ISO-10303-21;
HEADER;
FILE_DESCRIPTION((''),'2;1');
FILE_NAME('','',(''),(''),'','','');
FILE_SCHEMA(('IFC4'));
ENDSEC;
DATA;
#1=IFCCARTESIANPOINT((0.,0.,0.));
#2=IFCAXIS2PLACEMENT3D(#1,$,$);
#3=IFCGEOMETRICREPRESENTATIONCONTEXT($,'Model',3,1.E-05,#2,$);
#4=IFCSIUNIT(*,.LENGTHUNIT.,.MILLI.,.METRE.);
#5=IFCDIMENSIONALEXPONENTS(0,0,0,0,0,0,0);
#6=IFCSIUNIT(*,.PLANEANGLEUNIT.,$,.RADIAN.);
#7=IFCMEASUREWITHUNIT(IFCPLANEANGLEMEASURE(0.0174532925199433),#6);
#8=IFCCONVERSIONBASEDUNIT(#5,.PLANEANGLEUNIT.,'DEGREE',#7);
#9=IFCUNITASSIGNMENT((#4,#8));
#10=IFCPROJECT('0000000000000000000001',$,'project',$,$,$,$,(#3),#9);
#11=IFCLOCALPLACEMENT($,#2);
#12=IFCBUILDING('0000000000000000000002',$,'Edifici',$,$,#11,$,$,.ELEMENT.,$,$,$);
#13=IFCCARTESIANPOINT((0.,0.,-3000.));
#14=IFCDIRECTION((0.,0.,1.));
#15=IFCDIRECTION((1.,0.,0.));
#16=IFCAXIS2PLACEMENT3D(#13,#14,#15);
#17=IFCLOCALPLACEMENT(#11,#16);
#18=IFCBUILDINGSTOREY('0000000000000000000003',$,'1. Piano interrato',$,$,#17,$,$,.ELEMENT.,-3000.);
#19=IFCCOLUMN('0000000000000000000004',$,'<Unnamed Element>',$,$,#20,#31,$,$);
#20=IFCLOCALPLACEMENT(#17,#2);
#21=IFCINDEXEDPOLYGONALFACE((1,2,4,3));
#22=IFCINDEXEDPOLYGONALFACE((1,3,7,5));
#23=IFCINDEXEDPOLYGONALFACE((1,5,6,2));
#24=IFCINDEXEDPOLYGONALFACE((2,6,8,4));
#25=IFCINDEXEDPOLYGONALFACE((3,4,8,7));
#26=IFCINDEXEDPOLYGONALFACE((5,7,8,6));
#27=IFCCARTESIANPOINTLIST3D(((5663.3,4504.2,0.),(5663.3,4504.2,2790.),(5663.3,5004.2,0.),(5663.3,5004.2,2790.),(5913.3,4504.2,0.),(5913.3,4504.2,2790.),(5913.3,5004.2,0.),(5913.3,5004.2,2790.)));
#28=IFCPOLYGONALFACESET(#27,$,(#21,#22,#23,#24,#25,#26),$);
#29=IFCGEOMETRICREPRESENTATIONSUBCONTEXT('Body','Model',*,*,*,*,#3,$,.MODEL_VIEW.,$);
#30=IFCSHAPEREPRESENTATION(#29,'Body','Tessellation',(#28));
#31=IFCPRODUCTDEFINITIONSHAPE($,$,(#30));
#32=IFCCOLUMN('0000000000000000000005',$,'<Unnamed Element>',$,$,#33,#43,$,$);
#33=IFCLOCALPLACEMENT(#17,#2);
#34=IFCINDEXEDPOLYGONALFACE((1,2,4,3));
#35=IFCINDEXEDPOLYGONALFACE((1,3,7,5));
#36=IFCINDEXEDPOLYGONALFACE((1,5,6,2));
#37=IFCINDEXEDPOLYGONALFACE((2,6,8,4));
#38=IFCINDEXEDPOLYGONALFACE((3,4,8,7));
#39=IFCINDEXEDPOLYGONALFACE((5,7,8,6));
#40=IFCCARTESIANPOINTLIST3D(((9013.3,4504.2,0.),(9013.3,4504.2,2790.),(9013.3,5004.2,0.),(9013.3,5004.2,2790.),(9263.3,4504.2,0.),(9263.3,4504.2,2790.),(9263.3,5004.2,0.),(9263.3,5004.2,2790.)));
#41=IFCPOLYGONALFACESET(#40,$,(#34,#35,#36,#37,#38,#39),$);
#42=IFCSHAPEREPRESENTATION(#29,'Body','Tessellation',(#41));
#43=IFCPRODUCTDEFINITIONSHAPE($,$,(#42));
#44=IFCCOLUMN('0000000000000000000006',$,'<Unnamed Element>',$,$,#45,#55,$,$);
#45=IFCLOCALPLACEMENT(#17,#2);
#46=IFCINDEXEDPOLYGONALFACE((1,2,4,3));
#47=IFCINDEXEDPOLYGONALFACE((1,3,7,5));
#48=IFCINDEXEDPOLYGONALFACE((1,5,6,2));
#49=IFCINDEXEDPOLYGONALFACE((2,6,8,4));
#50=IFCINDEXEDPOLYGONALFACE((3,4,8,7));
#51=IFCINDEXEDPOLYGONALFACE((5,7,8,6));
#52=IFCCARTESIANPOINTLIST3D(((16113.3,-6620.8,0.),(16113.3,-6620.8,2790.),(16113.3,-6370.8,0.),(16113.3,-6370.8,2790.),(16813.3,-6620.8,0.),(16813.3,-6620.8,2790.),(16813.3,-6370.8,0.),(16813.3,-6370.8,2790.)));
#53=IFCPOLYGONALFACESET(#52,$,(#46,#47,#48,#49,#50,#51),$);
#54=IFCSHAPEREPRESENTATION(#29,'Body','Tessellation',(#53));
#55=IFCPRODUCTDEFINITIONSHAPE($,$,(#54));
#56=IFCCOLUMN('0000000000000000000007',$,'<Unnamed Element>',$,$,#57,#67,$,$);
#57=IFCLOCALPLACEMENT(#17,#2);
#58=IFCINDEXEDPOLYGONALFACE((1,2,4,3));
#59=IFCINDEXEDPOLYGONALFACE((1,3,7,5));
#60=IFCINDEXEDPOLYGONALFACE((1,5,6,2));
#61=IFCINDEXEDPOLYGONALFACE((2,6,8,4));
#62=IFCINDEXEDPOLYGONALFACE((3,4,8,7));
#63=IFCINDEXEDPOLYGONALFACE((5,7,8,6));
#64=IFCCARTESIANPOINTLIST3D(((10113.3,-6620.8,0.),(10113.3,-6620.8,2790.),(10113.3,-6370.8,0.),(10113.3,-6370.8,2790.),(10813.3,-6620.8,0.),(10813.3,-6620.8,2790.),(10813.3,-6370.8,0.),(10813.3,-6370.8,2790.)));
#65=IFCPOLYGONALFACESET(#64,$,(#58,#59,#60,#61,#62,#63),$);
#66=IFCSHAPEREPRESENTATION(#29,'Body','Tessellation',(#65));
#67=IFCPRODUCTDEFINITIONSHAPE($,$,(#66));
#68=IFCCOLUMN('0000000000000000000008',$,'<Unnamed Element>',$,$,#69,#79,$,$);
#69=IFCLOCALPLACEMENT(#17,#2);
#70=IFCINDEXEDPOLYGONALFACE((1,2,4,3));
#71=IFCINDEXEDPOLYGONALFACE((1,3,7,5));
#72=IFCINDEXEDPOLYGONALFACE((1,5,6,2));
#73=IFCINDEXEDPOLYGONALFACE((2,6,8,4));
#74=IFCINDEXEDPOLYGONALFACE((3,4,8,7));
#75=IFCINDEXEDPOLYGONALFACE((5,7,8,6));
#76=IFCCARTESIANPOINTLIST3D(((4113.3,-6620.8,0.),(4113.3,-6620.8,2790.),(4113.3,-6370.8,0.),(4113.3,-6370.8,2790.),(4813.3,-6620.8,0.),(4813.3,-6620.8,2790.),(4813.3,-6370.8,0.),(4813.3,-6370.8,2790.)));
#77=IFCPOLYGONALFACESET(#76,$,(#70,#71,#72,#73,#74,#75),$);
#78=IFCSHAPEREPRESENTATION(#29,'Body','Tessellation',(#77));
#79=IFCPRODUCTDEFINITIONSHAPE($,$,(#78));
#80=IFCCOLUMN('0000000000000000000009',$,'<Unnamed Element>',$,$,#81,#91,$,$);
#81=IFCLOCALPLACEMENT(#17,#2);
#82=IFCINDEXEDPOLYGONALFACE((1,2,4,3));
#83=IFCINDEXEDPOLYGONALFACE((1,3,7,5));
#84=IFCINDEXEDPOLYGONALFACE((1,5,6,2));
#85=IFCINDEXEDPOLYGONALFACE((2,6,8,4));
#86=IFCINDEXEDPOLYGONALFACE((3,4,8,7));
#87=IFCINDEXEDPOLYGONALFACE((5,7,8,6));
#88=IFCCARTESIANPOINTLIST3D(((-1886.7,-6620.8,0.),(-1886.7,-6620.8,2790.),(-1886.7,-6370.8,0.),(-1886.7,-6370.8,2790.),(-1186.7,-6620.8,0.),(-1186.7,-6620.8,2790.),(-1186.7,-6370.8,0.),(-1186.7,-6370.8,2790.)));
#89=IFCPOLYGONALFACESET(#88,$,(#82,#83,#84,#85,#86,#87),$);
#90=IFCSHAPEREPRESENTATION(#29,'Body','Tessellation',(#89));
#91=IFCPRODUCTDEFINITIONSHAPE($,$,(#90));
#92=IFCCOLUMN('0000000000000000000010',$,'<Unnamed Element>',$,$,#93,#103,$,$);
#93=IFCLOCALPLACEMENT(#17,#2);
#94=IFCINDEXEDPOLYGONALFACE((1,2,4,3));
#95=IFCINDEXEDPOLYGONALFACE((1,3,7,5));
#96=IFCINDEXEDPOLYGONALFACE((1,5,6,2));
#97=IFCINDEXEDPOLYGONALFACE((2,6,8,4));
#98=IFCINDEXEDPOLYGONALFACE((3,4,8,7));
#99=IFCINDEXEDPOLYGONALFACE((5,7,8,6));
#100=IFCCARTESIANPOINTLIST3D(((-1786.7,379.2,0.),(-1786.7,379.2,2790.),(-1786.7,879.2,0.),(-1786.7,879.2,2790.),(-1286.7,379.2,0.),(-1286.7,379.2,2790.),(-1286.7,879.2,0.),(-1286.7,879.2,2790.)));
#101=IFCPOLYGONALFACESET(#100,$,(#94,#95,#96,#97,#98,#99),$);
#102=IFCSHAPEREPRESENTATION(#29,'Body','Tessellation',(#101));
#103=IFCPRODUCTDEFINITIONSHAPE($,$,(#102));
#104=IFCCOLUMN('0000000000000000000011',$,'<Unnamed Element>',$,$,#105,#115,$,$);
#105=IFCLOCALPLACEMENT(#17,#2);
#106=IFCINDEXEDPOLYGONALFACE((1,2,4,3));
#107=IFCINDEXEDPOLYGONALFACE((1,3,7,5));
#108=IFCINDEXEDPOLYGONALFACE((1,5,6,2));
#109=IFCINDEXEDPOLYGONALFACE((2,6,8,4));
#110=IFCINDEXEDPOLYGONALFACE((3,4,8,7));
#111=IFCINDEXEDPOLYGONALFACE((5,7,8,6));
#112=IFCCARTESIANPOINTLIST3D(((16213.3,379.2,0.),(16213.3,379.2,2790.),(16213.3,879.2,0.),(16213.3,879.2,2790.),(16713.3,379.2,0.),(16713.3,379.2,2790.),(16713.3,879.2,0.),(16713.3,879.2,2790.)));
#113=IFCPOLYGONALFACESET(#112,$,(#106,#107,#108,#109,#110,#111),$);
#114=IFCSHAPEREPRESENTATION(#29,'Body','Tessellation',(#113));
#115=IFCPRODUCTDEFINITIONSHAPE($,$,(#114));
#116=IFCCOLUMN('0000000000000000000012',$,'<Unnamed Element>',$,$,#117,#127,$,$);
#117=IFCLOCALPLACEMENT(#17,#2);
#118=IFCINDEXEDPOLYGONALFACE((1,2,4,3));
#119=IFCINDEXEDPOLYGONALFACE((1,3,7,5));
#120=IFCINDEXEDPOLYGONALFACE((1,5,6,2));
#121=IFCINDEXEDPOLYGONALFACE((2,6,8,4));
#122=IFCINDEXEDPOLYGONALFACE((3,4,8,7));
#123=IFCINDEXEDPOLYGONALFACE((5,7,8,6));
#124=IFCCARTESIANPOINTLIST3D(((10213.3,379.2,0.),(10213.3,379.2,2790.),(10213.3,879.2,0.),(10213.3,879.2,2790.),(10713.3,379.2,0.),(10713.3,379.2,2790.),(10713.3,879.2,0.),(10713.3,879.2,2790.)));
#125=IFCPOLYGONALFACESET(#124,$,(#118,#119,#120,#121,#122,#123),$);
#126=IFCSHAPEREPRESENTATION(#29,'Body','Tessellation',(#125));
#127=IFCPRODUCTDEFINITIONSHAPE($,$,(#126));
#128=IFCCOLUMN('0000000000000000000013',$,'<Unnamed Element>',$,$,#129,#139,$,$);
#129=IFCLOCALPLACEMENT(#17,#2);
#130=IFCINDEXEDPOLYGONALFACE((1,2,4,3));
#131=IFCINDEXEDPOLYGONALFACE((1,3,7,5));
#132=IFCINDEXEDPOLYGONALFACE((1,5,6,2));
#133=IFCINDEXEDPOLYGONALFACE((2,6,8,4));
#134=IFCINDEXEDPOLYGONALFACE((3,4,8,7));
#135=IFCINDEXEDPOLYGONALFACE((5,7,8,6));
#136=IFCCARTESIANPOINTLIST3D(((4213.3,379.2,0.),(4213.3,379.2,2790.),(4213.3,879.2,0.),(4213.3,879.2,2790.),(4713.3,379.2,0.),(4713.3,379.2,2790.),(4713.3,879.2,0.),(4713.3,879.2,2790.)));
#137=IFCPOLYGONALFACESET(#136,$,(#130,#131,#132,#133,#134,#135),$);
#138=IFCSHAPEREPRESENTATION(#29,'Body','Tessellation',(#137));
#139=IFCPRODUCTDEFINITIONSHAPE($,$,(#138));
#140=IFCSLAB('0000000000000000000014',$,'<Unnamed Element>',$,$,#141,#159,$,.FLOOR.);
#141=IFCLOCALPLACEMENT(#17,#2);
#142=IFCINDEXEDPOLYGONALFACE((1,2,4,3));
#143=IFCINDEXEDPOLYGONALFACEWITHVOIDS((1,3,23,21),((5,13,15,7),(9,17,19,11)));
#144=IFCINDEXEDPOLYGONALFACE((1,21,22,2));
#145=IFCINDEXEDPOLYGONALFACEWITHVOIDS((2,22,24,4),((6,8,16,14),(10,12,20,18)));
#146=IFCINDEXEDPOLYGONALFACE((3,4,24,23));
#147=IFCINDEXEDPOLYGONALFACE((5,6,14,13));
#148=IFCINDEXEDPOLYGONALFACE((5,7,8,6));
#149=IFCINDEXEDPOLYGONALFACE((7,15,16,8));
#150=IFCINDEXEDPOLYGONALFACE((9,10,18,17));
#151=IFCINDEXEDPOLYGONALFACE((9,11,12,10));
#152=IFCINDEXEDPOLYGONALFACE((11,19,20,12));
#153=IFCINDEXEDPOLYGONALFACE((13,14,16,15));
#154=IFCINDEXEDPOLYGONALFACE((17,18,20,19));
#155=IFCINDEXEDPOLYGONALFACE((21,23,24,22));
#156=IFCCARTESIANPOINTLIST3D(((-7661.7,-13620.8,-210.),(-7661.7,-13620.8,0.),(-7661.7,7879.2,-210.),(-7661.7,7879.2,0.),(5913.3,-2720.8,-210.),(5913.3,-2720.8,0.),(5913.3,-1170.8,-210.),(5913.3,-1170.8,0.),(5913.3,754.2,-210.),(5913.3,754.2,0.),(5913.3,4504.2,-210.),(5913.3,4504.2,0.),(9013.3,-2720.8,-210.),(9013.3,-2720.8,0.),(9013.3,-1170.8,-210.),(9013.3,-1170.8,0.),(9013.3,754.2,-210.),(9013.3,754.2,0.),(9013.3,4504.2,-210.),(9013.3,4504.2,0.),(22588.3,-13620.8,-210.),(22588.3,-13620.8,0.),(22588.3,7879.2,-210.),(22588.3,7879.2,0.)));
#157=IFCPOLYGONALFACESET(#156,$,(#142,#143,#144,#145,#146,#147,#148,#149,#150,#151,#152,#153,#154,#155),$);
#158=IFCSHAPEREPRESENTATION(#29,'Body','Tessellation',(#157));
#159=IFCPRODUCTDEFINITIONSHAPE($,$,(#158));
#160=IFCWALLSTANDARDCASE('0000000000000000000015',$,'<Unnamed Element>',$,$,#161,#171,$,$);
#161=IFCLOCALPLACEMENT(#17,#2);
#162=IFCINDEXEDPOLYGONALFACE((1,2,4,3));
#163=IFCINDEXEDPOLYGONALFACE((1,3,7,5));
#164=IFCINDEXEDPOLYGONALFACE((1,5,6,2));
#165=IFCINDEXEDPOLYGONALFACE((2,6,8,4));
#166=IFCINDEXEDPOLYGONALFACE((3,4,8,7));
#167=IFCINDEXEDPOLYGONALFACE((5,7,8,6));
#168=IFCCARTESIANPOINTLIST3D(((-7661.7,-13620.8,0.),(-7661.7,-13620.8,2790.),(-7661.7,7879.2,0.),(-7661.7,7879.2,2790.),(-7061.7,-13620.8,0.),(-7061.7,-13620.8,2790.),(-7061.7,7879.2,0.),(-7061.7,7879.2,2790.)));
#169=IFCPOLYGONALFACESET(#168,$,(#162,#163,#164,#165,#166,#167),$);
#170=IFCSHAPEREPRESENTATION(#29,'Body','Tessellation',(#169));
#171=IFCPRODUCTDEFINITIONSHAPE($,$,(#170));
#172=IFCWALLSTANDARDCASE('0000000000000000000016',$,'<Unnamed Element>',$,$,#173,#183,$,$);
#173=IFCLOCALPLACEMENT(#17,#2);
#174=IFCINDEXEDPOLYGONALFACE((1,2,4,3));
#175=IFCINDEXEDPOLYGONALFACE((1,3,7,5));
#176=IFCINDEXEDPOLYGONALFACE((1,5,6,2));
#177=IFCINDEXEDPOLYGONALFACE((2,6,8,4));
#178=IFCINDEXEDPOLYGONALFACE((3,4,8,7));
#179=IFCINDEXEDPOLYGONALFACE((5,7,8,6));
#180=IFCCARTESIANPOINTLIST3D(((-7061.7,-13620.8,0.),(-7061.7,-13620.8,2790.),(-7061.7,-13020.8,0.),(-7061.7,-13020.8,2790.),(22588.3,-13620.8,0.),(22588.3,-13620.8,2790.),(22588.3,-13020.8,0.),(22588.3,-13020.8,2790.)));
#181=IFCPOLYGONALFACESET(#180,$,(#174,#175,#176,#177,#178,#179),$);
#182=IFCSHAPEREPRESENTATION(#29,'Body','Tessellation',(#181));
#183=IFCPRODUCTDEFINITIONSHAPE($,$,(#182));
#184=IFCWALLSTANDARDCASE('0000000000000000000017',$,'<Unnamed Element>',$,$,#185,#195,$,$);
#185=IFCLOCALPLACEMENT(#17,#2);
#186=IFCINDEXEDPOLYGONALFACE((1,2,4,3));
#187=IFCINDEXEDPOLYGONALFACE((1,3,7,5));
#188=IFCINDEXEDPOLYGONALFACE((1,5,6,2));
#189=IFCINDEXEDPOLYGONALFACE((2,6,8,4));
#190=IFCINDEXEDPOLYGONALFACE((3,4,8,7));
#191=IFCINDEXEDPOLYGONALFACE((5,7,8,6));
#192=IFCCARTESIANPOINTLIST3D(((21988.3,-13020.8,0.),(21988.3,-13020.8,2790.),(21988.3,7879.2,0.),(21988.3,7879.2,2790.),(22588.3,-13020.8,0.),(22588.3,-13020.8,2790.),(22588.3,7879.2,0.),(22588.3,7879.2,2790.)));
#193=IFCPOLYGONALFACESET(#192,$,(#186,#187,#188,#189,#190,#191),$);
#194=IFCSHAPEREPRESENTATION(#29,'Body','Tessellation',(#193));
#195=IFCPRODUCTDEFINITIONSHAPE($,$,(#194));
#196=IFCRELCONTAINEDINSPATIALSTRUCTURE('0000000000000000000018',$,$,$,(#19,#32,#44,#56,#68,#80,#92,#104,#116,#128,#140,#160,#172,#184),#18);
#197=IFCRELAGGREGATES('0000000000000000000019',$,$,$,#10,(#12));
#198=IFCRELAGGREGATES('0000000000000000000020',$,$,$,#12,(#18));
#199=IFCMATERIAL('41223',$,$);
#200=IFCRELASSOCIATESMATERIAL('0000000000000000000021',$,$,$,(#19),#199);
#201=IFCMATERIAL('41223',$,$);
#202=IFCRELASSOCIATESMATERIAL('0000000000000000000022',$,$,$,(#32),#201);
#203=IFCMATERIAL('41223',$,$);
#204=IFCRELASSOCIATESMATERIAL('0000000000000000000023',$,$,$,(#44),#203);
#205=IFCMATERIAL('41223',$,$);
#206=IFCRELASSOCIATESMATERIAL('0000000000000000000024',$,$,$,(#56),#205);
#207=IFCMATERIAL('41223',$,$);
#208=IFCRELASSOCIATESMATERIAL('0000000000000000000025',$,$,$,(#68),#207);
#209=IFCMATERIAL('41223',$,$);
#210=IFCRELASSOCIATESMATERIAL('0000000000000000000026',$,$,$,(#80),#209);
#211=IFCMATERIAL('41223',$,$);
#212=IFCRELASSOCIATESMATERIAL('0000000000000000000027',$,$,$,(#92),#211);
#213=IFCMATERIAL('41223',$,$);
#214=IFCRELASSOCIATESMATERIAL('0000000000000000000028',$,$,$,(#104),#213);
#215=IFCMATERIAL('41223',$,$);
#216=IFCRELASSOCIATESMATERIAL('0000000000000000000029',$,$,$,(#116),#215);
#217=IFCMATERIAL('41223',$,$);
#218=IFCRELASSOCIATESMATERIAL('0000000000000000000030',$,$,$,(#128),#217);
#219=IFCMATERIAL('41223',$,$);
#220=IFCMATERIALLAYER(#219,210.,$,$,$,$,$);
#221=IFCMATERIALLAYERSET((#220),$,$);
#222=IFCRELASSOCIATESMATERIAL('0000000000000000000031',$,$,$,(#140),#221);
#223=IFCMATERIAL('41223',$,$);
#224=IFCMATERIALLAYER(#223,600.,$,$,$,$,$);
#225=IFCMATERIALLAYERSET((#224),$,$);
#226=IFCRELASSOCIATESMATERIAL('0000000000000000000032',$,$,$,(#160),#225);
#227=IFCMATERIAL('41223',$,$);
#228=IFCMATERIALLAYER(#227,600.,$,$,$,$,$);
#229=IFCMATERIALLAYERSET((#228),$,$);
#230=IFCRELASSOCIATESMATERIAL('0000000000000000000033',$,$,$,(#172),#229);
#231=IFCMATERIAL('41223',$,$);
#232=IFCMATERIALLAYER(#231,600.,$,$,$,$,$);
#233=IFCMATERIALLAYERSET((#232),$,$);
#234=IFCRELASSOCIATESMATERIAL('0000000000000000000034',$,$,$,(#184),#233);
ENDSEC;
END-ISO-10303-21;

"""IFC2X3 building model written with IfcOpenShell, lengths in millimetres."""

from ifc_helpers import new_model, entity, si_unit, converted_unit, frame, frame_2d, origin, origin_with_axes, place, context, subcontext, project, spatial, polyline, rectangle, outline, extrude, material, layer, layer_set, layer_usage, element, save


model = new_model("IFC2X3")

# Units and contexts
model_context = context("Model", 3, precision=1e-05, world=origin())
body_context = subcontext(model_context, "Body", "Model", "MODEL_VIEW")
ifc_project = project(units=[si_unit("LENGTHUNIT", "METRE", prefix="MILLI"), converted_unit("PLANEANGLEUNIT", "DEGREE", entity("IfcPlaneAngleMeasure", 0.0174532925199433), si_unit("PLANEANGLEUNIT", "RADIAN"), dimensions=[0, 0, 0, 0, 0, 0, 0])], contexts=[model_context])

# Building, storey
building_placement = place(None, origin())
building = spatial("IfcBuilding", under=ifc_project, at=building_placement, Name="Edifici", CompositionType="ELEMENT")
storey_placement = place(building_placement, frame((0.0, 0.0, -3000.0), z_axis=(0.0, 0.0, 1.0), x_axis=(1.0, 0.0, 0.0)))
storey = spatial("IfcBuildingStorey", under=building, at=storey_placement, Name="1. Piano interrato", CompositionType="ELEMENT", Elevation=-3000.0)

# Columns
ifc_material_1 = material(Name="41223")
column_1_placement = place(storey_placement, frame((5913.3, 5004.2, 0.0), z_axis=(0.0, 0.0, 1.0), x_axis=(1.0, 0.0, 0.0)))
element("IfcColumn", 1, at=column_1_placement, inside=storey, material=ifc_material_1, Name="<Unnamed Element>", context=body_context, shape_type="SweptSolid", body=[
    extrude(rectangle(XDim=250.0, YDim=500.0, at=frame_2d((-125.0, -250.0), x_axis=(-1.0, 0.0))), origin_with_axes(), (0.0, 0.0, 1.0), 2790.0),
])
ifc_material_2 = material(Name="41223")
column_2_placement = place(storey_placement, frame((9263.3, 5004.2, 0.0), z_axis=(0.0, 0.0, 1.0), x_axis=(1.0, 0.0, 0.0)))
element("IfcColumn", 2, at=column_2_placement, inside=storey, material=ifc_material_2, Name="<Unnamed Element>", context=body_context, shape_type="SweptSolid", body=[
    extrude(rectangle(XDim=250.0, YDim=500.0, at=frame_2d((-125.0, -250.0), x_axis=(-1.0, 0.0))), origin_with_axes(), (0.0, 0.0, 1.0), 2790.0),
])
ifc_material_3 = material(Name="41223")
column_3_placement = place(storey_placement, frame((16813.3, -6620.8, 0.0), z_axis=(0.0, 0.0, 1.0), x_axis=(1.0, 0.0, 0.0)))
element("IfcColumn", 3, at=column_3_placement, inside=storey, material=ifc_material_3, Name="<Unnamed Element>", context=body_context, shape_type="SweptSolid", body=[
    extrude(rectangle(XDim=250.0, YDim=700.0, at=frame_2d((-350.0, 125.0), x_axis=(0.0, 1.0))), origin_with_axes(), (0.0, 0.0, 1.0), 2790.0),
])
ifc_material_4 = material(Name="41223")
column_4_placement = place(storey_placement, frame((10813.3, -6620.8, 0.0), z_axis=(0.0, 0.0, 1.0), x_axis=(1.0, 0.0, 0.0)))
element("IfcColumn", 4, at=column_4_placement, inside=storey, material=ifc_material_4, Name="<Unnamed Element>", context=body_context, shape_type="SweptSolid", body=[
    extrude(rectangle(XDim=250.0, YDim=700.0, at=frame_2d((-350.0, 125.0), x_axis=(0.0, 1.0))), origin_with_axes(), (0.0, 0.0, 1.0), 2790.0),
])
ifc_material_5 = material(Name="41223")
column_5_placement = place(storey_placement, frame((4813.3, -6620.8, 0.0), z_axis=(0.0, 0.0, 1.0), x_axis=(1.0, 0.0, 0.0)))
element("IfcColumn", 5, at=column_5_placement, inside=storey, material=ifc_material_5, Name="<Unnamed Element>", context=body_context, shape_type="SweptSolid", body=[
    extrude(rectangle(XDim=250.0, YDim=700.0, at=frame_2d((-350.0, 125.0), x_axis=(0.0, 1.0))), origin_with_axes(), (0.0, 0.0, 1.0), 2790.0),
])
ifc_material_6 = material(Name="41223")
column_6_placement = place(storey_placement, frame((-1186.7, -6620.8, 0.0), z_axis=(0.0, 0.0, 1.0), x_axis=(1.0, 0.0, 0.0)))
element("IfcColumn", 6, at=column_6_placement, inside=storey, material=ifc_material_6, Name="<Unnamed Element>", context=body_context, shape_type="SweptSolid", body=[
    extrude(rectangle(XDim=250.0, YDim=700.0, at=frame_2d((-350.0, 125.0), x_axis=(0.0, 1.0))), origin_with_axes(), (0.0, 0.0, 1.0), 2790.0),
])
ifc_material_7 = material(Name="41223")
column_7_placement = place(storey_placement, frame((-1786.7, 379.2, 0.0), z_axis=(0.0, 0.0, 1.0), x_axis=(1.0, 0.0, 0.0)))
element("IfcColumn", 7, at=column_7_placement, inside=storey, material=ifc_material_7, Name="<Unnamed Element>", context=body_context, shape_type="SweptSolid", body=[
    extrude(rectangle(XDim=500.0, YDim=500.0, at=frame_2d((250.0, 250.0), x_axis=(1.0, 0.0))), origin_with_axes(), (0.0, 0.0, 1.0), 2790.0),
])
ifc_material_8 = material(Name="41223")
column_8_placement = place(storey_placement, frame((16213.3, 379.2, 0.0), z_axis=(0.0, 0.0, 1.0), x_axis=(1.0, 0.0, 0.0)))
element("IfcColumn", 8, at=column_8_placement, inside=storey, material=ifc_material_8, Name="<Unnamed Element>", context=body_context, shape_type="SweptSolid", body=[
    extrude(rectangle(XDim=500.0, YDim=500.0, at=frame_2d((250.0, 250.0), x_axis=(1.0, 0.0))), origin_with_axes(), (0.0, 0.0, 1.0), 2790.0),
])
ifc_material_9 = material(Name="41223")
column_9_placement = place(storey_placement, frame((10213.3, 379.2, 0.0), z_axis=(0.0, 0.0, 1.0), x_axis=(1.0, 0.0, 0.0)))
element("IfcColumn", 9, at=column_9_placement, inside=storey, material=ifc_material_9, Name="<Unnamed Element>", context=body_context, shape_type="SweptSolid", body=[
    extrude(rectangle(XDim=500.0, YDim=500.0, at=frame_2d((250.0, 250.0), x_axis=(1.0, 0.0))), origin_with_axes(), (0.0, 0.0, 1.0), 2790.0),
])
ifc_material_10 = material(Name="41223")
column_10_placement = place(storey_placement, frame((4213.3, 379.2, 0.0), z_axis=(0.0, 0.0, 1.0), x_axis=(1.0, 0.0, 0.0)))
element("IfcColumn", 10, at=column_10_placement, inside=storey, material=ifc_material_10, Name="<Unnamed Element>", context=body_context, shape_type="SweptSolid", body=[
    extrude(rectangle(XDim=500.0, YDim=500.0, at=frame_2d((250.0, 250.0), x_axis=(1.0, 0.0))), origin_with_axes(), (0.0, 0.0, 1.0), 2790.0),
])

# Slab
ifc_material_11 = material(Name="41223")
ifc_layer_1 = layer(ifc_material_11, 210.0)
ifc_layer_set_1 = layer_set([ifc_layer_1])
ifc_layer_usage_1 = layer_usage(ifc_layer_set_1, "AXIS3", "POSITIVE", 0.0)
slab_placement = place(storey_placement, frame((-7661.7, -13620.8, -210.0), z_axis=(0.0, 0.0, 1.0), x_axis=(1.0, 0.0, 0.0)))
element("IfcSlab", 11, at=slab_placement, inside=storey, material=ifc_layer_usage_1, Name="<Unnamed Element>", PredefinedType="FLOOR", context=body_context, shape_type="SweptSolid", body=[
    extrude(outline(polyline([(0.0, 0.0), (30250.0, 0.0), (30250.0, 21500.0), (0.0, 21500.0), (0.0, 0.0)]), holes=[polyline([(13575.0, 18125.0), (16675.0, 18125.0), (16675.0, 14375.0), (13575.0, 14375.0), (13575.0, 18125.0)]), polyline([(16675.0, 10900.0), (13575.0, 10900.0), (13575.0, 12450.0), (16675.0, 12450.0), (16675.0, 10900.0)])]), origin_with_axes(), (0.0, 0.0, 1.0), 210.0),
])

# Walls
ifc_material_12 = material(Name="41223")
ifc_layer_2 = layer(ifc_material_12, 600.0)
ifc_layer_set_2 = layer_set([ifc_layer_2])
ifc_layer_usage_2 = layer_usage(ifc_layer_set_2, "AXIS2", "POSITIVE", 0.0)
wall_1_placement = place(storey_placement, frame((-7661.7, 7879.2, 0.0), z_axis=(0.0, 0.0, 1.0), x_axis=(0.0, -1.0, 0.0)))
element("IfcWallStandardCase", 12, at=wall_1_placement, inside=storey, material=ifc_layer_usage_2, Name="<Unnamed Element>", context=body_context, shape_type="SweptSolid", body=[
    extrude(rectangle(XDim=21500.0, YDim=600.0, at=frame_2d((10750.0, 300.0), x_axis=(1.0, 0.0))), origin_with_axes(), (0.0, 0.0, 1.0), 2790.0),
])
ifc_material_13 = material(Name="41223")
ifc_layer_3 = layer(ifc_material_13, 600.0)
ifc_layer_set_3 = layer_set([ifc_layer_3])
ifc_layer_usage_3 = layer_usage(ifc_layer_set_3, "AXIS2", "POSITIVE", 0.0)
wall_2_placement = place(storey_placement, frame((-7061.7, -13620.8, 0.0), z_axis=(0.0, 0.0, 1.0), x_axis=(1.0, 0.0, 0.0)))
element("IfcWallStandardCase", 13, at=wall_2_placement, inside=storey, material=ifc_layer_usage_3, Name="<Unnamed Element>", context=body_context, shape_type="SweptSolid", body=[
    extrude(rectangle(XDim=29650.0, YDim=600.0, at=frame_2d((14825.0, 300.0), x_axis=(1.0, 0.0))), origin_with_axes(), (0.0, 0.0, 1.0), 2790.0),
])
ifc_material_14 = material(Name="41223")
ifc_layer_4 = layer(ifc_material_14, 600.0)
ifc_layer_set_4 = layer_set([ifc_layer_4])
ifc_layer_usage_4 = layer_usage(ifc_layer_set_4, "AXIS2", "POSITIVE", 0.0)
wall_3_placement = place(storey_placement, frame((22588.3, -13020.8, 0.0), z_axis=(0.0, 0.0, 1.0), x_axis=(0.0, 1.0, 0.0)))
element("IfcWallStandardCase", 14, at=wall_3_placement, inside=storey, material=ifc_layer_usage_4, Name="<Unnamed Element>", context=body_context, shape_type="SweptSolid", body=[
    extrude(rectangle(XDim=20900.0, YDim=600.0, at=frame_2d((10450.0, 300.0), x_axis=(1.0, 0.0))), origin_with_axes(), (0.0, 0.0, 1.0), 2790.0),
])

save(model, "model.ifc")
